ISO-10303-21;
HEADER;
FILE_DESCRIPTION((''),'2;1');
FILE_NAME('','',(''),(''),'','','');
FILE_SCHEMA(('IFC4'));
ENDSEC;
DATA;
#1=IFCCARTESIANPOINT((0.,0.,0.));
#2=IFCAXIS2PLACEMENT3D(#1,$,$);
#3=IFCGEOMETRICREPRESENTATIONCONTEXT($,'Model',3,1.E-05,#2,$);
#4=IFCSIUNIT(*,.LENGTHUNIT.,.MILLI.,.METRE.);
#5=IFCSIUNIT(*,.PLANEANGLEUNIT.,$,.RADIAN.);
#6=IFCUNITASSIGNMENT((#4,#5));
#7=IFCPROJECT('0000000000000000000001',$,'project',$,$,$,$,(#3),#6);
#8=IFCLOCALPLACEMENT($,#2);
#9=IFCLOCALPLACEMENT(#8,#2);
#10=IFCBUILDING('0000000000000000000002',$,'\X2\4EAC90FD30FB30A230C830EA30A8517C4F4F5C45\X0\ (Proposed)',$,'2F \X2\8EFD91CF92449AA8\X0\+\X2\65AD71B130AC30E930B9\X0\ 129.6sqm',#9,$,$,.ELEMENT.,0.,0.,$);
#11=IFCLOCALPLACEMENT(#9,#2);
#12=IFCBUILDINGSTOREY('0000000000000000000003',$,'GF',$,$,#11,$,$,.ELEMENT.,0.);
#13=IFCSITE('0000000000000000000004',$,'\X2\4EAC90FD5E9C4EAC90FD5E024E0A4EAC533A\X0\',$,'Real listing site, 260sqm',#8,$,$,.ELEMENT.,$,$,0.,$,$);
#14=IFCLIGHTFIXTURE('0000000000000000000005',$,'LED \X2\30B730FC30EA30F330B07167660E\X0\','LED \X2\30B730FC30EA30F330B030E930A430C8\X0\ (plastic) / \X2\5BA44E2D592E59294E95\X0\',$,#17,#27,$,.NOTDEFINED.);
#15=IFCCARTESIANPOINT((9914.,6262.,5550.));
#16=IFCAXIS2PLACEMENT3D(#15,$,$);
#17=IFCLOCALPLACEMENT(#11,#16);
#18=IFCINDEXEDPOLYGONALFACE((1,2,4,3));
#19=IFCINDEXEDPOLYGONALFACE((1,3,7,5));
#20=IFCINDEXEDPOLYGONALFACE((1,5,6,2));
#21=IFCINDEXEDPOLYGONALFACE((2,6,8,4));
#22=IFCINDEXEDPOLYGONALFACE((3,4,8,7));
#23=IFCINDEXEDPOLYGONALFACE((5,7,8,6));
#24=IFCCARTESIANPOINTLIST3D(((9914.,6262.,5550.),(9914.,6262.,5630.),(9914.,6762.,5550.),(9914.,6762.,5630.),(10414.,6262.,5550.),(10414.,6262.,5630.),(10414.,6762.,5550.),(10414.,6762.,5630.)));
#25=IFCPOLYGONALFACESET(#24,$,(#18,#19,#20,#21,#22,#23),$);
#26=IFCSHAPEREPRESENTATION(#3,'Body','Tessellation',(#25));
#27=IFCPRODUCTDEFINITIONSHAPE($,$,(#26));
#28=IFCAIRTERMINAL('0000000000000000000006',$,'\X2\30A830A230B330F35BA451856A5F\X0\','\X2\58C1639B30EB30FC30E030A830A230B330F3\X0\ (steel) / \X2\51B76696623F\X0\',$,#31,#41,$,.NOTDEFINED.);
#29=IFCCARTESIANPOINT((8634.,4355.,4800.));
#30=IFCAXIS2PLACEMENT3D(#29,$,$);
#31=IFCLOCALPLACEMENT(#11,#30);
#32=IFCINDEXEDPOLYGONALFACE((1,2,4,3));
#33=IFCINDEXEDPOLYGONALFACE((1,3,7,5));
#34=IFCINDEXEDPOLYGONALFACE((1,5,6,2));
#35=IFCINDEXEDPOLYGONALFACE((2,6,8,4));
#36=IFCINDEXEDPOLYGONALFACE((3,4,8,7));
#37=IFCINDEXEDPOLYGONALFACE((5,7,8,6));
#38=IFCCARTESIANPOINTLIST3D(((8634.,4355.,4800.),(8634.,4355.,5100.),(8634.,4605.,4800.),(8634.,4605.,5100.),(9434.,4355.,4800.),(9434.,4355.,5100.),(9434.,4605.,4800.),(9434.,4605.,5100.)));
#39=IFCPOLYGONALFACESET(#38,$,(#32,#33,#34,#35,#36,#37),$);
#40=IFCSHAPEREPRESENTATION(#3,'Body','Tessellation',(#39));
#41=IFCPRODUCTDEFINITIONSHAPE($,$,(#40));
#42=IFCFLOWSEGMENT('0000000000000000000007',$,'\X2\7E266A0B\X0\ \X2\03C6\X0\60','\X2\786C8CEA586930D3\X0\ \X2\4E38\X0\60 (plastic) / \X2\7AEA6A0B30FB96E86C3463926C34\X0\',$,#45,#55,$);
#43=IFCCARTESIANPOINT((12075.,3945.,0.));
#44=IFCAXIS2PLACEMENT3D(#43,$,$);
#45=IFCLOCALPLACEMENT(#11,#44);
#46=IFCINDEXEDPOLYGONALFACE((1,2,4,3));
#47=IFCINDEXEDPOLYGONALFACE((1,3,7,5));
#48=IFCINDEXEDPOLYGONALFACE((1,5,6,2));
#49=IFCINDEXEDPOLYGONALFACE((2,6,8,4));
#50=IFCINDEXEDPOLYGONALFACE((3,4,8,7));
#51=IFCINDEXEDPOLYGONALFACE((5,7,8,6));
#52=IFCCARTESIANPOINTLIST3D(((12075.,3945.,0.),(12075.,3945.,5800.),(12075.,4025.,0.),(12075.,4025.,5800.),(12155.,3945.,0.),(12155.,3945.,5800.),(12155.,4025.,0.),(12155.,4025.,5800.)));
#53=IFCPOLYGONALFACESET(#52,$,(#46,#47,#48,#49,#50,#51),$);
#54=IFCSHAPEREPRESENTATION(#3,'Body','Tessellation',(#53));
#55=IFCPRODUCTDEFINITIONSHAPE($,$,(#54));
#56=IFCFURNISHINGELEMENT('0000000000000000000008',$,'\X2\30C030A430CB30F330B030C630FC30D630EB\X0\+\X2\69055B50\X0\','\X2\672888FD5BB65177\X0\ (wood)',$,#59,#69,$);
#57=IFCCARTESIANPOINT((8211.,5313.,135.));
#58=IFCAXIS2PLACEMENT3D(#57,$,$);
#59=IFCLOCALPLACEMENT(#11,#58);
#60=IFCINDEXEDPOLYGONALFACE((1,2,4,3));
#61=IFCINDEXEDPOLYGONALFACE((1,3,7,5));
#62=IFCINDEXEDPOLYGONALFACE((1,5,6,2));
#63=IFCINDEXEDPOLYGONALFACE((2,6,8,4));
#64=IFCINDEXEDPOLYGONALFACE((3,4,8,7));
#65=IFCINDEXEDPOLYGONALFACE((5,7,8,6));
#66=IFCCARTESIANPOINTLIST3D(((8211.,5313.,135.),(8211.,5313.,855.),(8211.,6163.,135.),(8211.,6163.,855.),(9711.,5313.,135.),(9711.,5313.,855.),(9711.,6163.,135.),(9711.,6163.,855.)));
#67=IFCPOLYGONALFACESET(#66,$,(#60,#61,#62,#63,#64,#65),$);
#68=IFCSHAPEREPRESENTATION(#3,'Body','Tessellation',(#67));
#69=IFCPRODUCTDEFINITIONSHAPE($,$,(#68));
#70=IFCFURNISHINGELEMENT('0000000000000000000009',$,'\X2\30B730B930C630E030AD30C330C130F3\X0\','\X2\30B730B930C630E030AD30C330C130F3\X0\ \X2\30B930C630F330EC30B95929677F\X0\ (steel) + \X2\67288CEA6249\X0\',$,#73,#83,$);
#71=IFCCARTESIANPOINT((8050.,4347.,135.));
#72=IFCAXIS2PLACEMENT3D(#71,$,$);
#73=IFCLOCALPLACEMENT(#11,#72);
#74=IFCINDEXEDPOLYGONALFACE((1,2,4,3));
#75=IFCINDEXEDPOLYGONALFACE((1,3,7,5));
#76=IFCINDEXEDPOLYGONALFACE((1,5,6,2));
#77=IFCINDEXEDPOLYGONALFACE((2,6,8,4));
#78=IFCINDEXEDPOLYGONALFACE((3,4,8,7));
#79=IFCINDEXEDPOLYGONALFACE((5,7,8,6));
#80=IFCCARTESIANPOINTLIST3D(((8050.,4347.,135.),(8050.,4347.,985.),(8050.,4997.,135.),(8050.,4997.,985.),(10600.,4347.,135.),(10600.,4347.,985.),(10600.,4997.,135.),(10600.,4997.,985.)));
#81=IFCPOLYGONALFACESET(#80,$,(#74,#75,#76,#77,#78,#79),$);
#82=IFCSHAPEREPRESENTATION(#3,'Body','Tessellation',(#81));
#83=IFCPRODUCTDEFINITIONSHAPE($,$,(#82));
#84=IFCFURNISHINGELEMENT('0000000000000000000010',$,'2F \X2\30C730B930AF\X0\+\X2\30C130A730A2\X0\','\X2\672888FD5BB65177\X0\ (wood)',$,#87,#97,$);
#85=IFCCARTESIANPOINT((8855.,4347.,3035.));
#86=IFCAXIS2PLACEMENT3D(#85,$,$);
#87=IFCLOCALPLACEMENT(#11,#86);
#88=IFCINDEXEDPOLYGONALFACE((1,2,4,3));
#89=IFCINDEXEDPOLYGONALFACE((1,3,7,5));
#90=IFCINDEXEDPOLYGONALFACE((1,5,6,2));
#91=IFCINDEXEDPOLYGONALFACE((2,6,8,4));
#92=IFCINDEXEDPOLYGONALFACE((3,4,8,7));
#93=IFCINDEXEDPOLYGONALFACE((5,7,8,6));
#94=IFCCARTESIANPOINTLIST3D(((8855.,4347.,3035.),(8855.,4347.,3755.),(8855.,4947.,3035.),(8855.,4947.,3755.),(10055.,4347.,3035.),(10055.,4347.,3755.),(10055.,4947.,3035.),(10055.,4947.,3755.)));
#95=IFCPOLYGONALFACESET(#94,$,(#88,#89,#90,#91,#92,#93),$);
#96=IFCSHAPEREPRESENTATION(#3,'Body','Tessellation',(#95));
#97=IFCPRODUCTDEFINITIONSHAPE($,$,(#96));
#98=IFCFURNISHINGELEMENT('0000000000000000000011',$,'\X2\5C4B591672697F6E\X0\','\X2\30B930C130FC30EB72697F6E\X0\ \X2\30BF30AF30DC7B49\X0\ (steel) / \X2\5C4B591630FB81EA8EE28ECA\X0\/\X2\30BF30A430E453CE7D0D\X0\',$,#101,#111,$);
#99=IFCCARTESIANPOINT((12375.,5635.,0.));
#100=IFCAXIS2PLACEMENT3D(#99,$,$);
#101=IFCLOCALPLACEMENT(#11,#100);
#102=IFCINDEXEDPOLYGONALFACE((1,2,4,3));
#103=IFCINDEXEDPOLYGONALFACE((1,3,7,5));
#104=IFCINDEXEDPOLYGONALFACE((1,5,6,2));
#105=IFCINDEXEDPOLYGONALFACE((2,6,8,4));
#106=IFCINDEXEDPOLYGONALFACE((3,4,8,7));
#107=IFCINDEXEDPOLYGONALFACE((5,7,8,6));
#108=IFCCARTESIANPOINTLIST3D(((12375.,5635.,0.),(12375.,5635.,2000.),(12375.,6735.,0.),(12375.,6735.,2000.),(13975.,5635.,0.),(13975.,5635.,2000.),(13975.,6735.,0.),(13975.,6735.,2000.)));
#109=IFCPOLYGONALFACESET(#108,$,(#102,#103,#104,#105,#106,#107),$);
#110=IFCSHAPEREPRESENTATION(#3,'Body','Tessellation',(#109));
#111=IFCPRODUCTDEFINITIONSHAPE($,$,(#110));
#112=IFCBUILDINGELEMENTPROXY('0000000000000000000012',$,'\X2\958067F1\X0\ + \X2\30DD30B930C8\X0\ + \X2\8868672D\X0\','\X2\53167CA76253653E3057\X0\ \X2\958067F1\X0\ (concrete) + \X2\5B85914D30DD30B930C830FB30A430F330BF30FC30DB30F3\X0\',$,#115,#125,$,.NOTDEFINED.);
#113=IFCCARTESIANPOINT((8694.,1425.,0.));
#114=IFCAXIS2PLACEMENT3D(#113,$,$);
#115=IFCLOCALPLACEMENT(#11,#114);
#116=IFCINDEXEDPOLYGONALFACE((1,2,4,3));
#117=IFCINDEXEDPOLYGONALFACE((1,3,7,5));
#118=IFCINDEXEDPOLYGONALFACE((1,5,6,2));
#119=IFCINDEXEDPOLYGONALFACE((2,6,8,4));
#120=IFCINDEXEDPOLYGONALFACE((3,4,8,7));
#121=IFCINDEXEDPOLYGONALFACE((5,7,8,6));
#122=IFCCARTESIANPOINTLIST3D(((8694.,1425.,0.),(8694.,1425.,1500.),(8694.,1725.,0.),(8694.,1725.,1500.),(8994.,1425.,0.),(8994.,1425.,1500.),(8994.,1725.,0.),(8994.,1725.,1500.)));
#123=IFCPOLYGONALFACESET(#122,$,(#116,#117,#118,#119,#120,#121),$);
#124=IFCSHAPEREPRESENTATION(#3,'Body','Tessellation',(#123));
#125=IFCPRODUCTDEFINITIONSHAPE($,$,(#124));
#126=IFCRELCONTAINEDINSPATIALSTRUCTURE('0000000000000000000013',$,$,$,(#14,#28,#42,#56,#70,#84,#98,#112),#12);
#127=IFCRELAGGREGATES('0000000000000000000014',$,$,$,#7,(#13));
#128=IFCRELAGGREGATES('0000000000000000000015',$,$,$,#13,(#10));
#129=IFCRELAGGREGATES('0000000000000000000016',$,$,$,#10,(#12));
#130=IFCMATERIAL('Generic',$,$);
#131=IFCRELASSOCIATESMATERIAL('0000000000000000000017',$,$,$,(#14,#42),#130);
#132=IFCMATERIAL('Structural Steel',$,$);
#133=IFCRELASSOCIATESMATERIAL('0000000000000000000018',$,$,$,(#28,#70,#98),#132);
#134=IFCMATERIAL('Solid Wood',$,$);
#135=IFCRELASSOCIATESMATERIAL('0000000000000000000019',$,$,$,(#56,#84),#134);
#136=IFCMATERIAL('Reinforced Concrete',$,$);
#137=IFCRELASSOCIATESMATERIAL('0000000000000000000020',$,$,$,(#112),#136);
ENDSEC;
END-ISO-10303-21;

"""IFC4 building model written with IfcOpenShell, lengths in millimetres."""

from ifc_helpers import new_model, si_unit, frame, frame_2d, origin, place, context, project, spatial, rectangle, extrude, material, element, save


model = new_model("IFC4")

# Units and contexts
model_context = context("Model", 3, precision=1e-05, world=origin())
ifc_project = project(units=[si_unit("LENGTHUNIT", "METRE", prefix="MILLI"), si_unit("PLANEANGLEUNIT", "RADIAN")], contexts=[model_context])

# Site, building, storey
site_placement = place(None, origin())
site = spatial("IfcSite", under=ifc_project, at=site_placement, Name="京都府京都市上京区", ObjectType="Real listing site, 260sqm", CompositionType="ELEMENT", RefElevation=0.0)
building_placement = place(site_placement, origin())
building = spatial("IfcBuilding", under=site, at=building_placement, Name="京都・アトリエ兼住居 (Proposed)", ObjectType="2F 軽量鉄骨+断熱ガラス 129.6sqm", CompositionType="ELEMENT", ElevationOfRefHeight=0.0, ElevationOfTerrain=0.0)
storey_placement = place(building_placement, origin())
storey = spatial("IfcBuildingStorey", under=building, at=storey_placement, Name="GF", CompositionType="ELEMENT", Elevation=0.0)

# Shared definitions
ifc_material_1 = material(Name="Solid Wood")

# Shared definitions
ifc_material_2 = material(Name="Reinforced Concrete")

# Shared definitions
ifc_material_3 = material(Name="Structural Steel")

# Shared definitions
ifc_material_4 = material(Name="Generic")

# Light fixture
light_fixture_placement = place(storey_placement, frame((9914.0, 6262.0, 5550.0)))
element("IfcLightFixture", 1, at=light_fixture_placement, inside=storey, material=ifc_material_4, Name="LED シーリング照明", Description="LED シーリングライト (plastic) / 室中央天井", PredefinedType="NOTDEFINED", context=model_context, shape_type="SweptSolid", body=[
    extrude(rectangle(XDim=500.0, YDim=500.0, at=frame_2d((250.0, 250.0))), frame((9914.0, 6262.0, 5550.0)), (0.0, 0.0, 1.0), 80.0),
])

# Air terminal
air_terminal_placement = place(storey_placement, frame((8634.0, 4355.0, 4800.0)))
element("IfcAirTerminal", 2, at=air_terminal_placement, inside=storey, material=ifc_material_3, Name="エアコン室内機", Description="壁掛ルームエアコン (steel) / 冷暖房", PredefinedType="NOTDEFINED", context=model_context, shape_type="SweptSolid", body=[
    extrude(rectangle(XDim=800.0, YDim=250.0, at=frame_2d((400.0, 125.0))), frame((8634.0, 4355.0, 4800.0)), (0.0, 0.0, 1.0), 300.0),
])

# Flow segment
flow_segment_placement = place(storey_placement, frame((12075.0, 3945.0, 0.0)))
element("IfcFlowSegment", 3, at=flow_segment_placement, inside=storey, material=ifc_material_4, Name="縦樋 φ60", Description="硬質塩ビ 丸60 (plastic) / 竪樋・雨水排水", context=model_context, shape_type="SweptSolid", body=[
    extrude(rectangle(XDim=80.0, YDim=80.0, at=frame_2d((40.0, 40.0))), frame((12075.0, 3945.0, 0.0)), (0.0, 0.0, 1.0), 5800.0),
])

# Furnishing elements
furnishing_1_placement = place(storey_placement, frame((8211.0, 5313.0, 135.0)))
element("IfcFurnishingElement", 4, at=furnishing_1_placement, inside=storey, material=ifc_material_1, Name="ダイニングテーブル+椅子", Description="木製家具 (wood)", context=model_context, shape_type="SweptSolid", body=[
    extrude(rectangle(XDim=1500.0, YDim=850.0, at=frame_2d((750.0, 425.0))), frame((8211.0, 5313.0, 135.0)), (0.0, 0.0, 1.0), 720.0),
])
furnishing_2_placement = place(storey_placement, frame((8050.0, 4347.0, 135.0)))
element("IfcFurnishingElement", 5, at=furnishing_2_placement, inside=storey, material=ifc_material_3, Name="システムキッチン", Description="システムキッチン ステンレス天板 (steel) + 木質扉", context=model_context, shape_type="SweptSolid", body=[
    extrude(rectangle(XDim=2550.0, YDim=650.0, at=frame_2d((1275.0, 325.0))), frame((8050.0, 4347.0, 135.0)), (0.0, 0.0, 1.0), 850.0),
])
furnishing_3_placement = place(storey_placement, frame((8855.0, 4347.0, 3035.0)))
element("IfcFurnishingElement", 6, at=furnishing_3_placement, inside=storey, material=ifc_material_1, Name="2F デスク+チェア", Description="木製家具 (wood)", context=model_context, shape_type="SweptSolid", body=[
    extrude(rectangle(XDim=1200.0, YDim=600.0, at=frame_2d((600.0, 300.0))), frame((8855.0, 4347.0, 3035.0)), (0.0, 0.0, 1.0), 720.0),
])
furnishing_4_placement = place(storey_placement, frame((12375.0, 5635.0, 0.0)))
element("IfcFurnishingElement", 7, at=furnishing_4_placement, inside=storey, material=ifc_material_3, Name="屋外物置", Description="スチール物置 タクボ等 (steel) / 屋外・自転車/タイヤ収納", context=model_context, shape_type="SweptSolid", body=[
    extrude(rectangle(XDim=1600.0, YDim=1100.0, at=frame_2d((800.0, 550.0))), frame((12375.0, 5635.0, 0.0)), (0.0, 0.0, 1.0), 2000.0),
])

# Building element proxy
proxy_placement = place(storey_placement, frame((8694.0, 1425.0, 0.0)))
element("IfcBuildingElementProxy", 8, at=proxy_placement, inside=storey, material=ifc_material_2, Name="門柱 + ポスト + 表札", Description="化粧打放し 門柱 (concrete) + 宅配ポスト・インターホン", PredefinedType="NOTDEFINED", context=model_context, shape_type="SweptSolid", body=[
    extrude(rectangle(XDim=300.0, YDim=300.0, at=frame_2d((150.0, 150.0))), frame((8694.0, 1425.0, 0.0)), (0.0, 0.0, 1.0), 1500.0),
])

save(model, "model.ifc")
